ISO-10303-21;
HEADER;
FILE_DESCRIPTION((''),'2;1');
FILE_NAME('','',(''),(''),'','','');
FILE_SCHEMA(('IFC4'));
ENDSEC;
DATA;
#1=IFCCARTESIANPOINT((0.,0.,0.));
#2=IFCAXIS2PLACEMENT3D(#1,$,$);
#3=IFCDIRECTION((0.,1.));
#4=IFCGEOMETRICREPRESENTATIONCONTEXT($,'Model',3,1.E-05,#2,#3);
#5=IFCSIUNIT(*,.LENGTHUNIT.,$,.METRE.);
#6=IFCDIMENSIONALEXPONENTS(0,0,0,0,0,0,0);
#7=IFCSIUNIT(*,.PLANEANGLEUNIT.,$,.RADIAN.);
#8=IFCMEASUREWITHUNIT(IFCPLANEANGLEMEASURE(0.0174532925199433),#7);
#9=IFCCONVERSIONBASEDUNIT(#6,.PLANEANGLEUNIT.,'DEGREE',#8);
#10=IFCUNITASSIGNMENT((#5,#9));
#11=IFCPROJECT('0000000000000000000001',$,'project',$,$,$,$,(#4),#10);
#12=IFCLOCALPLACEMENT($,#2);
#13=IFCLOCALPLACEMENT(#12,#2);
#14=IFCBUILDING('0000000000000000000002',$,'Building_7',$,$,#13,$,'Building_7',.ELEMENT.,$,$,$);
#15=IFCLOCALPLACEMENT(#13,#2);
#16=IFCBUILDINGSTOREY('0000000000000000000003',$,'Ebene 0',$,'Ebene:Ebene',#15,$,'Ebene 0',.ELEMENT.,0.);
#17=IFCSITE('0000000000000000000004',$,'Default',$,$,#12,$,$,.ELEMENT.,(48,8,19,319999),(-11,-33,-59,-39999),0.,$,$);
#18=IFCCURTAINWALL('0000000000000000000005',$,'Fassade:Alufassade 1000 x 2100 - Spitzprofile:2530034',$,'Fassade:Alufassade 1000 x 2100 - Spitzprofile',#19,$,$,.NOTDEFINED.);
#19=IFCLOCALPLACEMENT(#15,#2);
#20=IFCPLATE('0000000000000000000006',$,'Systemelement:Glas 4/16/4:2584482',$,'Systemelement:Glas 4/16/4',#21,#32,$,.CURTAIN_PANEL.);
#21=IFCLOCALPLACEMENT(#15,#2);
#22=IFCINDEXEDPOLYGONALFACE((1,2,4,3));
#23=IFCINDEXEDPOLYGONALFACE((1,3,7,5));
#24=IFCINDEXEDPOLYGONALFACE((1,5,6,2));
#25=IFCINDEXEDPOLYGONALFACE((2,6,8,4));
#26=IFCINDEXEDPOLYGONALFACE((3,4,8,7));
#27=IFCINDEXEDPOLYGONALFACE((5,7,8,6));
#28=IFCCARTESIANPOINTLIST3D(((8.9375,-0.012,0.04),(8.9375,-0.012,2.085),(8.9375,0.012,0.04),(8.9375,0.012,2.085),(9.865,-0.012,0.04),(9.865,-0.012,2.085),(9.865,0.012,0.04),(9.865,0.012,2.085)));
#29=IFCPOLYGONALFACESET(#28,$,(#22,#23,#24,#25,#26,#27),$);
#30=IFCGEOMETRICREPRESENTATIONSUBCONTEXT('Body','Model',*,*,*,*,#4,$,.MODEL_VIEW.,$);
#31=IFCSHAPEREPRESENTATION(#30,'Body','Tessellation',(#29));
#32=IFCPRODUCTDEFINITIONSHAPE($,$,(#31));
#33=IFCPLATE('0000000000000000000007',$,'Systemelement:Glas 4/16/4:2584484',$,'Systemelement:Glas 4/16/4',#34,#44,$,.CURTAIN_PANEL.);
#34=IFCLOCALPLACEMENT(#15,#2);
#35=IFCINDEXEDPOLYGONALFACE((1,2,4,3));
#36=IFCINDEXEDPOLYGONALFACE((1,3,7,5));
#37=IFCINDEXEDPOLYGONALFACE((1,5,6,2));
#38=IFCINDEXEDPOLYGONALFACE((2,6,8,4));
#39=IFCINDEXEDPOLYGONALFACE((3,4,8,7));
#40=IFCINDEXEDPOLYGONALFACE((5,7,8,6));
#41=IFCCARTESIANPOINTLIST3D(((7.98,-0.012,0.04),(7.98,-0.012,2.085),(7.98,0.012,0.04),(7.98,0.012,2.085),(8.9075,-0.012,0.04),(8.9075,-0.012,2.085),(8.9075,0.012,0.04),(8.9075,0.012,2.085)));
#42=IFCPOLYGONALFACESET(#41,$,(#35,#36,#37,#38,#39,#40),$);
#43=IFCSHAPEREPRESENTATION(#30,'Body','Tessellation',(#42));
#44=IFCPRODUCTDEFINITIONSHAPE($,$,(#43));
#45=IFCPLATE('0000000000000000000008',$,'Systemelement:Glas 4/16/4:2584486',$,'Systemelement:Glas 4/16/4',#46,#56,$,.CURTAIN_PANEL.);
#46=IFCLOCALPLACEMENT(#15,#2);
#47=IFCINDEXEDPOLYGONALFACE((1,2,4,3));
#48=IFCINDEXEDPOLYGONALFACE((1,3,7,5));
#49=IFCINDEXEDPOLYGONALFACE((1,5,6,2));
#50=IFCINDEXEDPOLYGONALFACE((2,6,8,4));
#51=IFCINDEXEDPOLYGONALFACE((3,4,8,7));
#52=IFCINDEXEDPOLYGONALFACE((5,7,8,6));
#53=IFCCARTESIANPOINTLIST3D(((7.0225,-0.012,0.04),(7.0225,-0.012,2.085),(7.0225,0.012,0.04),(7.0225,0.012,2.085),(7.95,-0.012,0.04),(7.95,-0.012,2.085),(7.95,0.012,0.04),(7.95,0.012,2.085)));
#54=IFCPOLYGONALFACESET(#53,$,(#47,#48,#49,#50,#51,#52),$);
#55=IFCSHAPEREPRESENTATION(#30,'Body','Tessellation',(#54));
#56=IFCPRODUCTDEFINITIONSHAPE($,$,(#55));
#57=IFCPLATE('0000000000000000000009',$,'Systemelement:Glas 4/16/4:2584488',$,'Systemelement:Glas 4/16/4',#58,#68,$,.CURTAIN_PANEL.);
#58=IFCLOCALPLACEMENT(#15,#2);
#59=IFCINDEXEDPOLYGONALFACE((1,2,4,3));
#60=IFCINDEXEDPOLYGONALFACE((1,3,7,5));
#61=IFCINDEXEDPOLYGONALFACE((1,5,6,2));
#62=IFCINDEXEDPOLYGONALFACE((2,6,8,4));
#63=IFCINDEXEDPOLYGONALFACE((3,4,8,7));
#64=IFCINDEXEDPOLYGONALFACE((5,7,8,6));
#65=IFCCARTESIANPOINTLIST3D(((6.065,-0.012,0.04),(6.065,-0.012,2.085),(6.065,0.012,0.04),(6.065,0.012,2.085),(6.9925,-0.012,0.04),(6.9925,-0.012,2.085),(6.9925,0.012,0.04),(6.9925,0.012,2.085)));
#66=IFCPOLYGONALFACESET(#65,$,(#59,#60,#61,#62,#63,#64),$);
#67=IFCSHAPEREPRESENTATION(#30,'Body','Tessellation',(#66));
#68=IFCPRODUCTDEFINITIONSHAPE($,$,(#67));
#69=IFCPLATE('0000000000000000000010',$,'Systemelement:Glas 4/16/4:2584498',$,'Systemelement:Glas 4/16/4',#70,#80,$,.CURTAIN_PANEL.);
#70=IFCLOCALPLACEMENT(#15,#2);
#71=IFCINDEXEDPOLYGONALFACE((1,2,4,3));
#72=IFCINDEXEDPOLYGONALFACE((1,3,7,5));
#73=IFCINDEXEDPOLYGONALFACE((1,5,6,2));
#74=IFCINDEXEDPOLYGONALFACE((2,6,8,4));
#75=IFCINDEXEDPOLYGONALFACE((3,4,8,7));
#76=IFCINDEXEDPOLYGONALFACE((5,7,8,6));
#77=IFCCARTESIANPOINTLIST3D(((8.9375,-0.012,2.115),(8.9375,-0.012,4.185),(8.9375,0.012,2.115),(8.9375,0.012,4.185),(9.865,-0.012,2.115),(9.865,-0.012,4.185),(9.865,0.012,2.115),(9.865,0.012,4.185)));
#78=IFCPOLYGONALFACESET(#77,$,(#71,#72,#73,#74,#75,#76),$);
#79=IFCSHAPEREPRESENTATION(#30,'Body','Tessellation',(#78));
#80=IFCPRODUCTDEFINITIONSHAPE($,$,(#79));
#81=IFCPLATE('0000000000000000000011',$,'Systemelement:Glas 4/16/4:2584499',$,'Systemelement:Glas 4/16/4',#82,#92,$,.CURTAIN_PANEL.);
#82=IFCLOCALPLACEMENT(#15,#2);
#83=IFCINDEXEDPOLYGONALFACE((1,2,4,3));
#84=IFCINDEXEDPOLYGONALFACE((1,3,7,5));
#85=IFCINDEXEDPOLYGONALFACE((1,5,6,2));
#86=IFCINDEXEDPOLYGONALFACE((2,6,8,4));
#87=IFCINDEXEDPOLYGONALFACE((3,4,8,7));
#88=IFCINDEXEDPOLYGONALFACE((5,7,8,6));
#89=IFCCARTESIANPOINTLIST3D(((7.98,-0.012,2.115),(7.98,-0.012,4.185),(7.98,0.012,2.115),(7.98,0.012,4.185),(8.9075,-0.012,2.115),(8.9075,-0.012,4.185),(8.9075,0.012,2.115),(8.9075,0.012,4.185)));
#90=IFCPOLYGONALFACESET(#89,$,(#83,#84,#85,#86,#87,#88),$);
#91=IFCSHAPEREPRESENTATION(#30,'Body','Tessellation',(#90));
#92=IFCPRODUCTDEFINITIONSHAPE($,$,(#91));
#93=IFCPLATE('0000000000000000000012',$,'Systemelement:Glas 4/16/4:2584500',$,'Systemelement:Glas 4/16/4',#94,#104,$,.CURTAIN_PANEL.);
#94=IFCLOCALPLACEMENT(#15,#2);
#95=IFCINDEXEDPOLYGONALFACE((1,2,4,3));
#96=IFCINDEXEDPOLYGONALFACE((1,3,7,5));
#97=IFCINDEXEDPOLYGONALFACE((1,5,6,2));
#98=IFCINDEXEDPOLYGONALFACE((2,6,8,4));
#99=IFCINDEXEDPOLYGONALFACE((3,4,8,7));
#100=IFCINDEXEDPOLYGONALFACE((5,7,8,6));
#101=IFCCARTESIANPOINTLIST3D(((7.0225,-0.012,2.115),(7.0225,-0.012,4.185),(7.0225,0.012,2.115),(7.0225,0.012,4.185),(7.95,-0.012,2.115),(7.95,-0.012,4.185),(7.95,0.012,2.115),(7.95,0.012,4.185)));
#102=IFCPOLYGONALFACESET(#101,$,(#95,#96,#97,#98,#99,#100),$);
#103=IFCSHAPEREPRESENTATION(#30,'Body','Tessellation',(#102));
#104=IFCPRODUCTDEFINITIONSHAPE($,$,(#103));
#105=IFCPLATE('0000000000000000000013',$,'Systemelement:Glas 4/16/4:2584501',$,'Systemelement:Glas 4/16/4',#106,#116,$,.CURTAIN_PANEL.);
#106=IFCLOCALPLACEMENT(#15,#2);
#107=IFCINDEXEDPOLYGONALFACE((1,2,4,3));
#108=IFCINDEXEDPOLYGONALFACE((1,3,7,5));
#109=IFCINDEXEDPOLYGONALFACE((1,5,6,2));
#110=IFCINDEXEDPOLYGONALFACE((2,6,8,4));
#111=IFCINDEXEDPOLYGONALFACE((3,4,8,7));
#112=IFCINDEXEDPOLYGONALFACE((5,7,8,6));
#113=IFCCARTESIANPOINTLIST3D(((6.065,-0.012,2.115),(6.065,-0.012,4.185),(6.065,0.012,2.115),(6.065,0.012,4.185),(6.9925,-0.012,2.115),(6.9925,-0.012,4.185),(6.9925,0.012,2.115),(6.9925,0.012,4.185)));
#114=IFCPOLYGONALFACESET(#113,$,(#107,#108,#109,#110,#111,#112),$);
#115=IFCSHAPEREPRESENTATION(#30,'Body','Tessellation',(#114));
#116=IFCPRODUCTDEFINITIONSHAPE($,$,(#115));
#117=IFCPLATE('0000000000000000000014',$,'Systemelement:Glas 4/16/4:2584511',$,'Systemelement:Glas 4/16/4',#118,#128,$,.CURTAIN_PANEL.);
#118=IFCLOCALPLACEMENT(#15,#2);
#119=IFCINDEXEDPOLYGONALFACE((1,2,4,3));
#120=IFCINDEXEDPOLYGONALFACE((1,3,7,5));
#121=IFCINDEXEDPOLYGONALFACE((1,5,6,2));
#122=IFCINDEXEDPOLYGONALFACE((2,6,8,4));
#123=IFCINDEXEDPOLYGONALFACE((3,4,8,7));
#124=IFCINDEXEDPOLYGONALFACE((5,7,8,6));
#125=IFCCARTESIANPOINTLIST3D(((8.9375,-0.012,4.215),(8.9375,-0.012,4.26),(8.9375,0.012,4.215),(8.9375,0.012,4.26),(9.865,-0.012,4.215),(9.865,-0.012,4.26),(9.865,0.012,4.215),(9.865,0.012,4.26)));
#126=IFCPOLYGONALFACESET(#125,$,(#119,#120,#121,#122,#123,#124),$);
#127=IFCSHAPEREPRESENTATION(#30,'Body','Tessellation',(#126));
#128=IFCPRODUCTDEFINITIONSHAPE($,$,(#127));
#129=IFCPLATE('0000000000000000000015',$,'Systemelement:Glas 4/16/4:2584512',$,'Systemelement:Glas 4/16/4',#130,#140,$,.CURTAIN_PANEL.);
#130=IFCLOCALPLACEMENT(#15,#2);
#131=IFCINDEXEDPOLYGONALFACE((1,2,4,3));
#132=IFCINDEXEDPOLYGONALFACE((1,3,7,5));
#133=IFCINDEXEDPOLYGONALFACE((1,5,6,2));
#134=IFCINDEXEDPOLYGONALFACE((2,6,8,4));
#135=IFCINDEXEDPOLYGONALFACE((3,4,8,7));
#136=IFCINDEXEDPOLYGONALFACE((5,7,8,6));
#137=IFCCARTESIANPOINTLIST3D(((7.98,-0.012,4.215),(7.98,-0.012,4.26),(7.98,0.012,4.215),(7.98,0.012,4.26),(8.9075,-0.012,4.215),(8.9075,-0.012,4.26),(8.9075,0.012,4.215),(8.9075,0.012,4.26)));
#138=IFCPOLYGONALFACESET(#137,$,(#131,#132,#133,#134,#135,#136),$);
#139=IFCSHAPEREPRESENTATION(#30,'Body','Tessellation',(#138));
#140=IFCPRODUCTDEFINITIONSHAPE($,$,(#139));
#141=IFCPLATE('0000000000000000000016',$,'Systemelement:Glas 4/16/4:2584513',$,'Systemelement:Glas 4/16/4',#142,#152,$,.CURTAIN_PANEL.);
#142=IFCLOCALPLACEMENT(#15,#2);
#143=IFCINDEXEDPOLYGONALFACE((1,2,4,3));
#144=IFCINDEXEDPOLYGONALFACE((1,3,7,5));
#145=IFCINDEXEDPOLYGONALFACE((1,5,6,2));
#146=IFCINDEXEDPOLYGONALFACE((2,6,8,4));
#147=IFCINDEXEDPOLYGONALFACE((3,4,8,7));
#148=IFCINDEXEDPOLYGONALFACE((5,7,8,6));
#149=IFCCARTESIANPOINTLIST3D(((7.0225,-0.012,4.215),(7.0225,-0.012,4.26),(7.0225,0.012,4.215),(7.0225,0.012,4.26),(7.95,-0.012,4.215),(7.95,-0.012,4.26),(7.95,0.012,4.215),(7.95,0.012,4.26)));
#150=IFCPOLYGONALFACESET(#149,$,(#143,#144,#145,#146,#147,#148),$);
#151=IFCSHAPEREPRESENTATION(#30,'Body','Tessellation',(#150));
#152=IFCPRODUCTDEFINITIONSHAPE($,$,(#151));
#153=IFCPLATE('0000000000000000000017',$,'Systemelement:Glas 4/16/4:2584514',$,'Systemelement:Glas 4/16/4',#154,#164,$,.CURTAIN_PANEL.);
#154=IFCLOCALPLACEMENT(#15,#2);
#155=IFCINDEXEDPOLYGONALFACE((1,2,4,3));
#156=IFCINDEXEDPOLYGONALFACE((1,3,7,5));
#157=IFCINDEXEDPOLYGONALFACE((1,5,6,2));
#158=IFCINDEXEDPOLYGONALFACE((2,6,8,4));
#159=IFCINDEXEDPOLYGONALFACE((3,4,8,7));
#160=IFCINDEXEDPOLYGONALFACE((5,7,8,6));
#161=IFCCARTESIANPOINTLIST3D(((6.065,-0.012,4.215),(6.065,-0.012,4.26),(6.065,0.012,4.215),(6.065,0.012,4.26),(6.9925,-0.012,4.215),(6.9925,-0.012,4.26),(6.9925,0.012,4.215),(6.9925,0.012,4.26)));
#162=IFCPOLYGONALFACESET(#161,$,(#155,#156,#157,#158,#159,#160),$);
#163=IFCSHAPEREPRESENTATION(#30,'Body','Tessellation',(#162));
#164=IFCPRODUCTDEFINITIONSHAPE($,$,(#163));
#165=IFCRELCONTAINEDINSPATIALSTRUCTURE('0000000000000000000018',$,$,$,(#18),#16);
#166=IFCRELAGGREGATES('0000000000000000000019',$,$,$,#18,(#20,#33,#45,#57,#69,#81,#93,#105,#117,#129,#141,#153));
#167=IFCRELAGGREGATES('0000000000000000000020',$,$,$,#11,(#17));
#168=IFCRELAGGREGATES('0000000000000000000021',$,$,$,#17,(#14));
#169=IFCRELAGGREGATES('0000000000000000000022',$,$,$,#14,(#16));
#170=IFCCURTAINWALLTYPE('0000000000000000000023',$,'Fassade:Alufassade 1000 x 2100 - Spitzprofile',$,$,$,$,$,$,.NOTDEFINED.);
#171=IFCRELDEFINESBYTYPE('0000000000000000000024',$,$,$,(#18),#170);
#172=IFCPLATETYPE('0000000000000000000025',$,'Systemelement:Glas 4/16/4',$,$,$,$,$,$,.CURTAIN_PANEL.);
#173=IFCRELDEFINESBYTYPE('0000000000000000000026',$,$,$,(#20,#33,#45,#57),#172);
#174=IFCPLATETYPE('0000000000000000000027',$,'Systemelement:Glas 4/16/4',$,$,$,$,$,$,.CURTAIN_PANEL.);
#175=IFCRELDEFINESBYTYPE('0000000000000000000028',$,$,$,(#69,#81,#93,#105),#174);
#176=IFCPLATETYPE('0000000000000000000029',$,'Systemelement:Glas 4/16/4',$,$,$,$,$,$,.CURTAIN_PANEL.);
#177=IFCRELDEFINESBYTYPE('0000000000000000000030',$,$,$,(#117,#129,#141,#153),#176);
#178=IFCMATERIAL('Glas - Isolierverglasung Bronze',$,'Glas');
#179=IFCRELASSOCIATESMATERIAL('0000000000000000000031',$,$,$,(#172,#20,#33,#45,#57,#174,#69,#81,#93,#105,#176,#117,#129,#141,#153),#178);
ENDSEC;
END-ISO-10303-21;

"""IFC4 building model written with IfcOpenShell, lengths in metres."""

from ifc_helpers import new_model, entity, si_unit, converted_unit, direction, frame, origin, place, context, subcontext, project, spatial, indexed_curve, outline, extrude, source, transform, mapped, material, type_object, type_shapes, element, aggregate, save


model = new_model("IFC4")

# Units and contexts
model_context = context("Model", 3, precision=1e-05, world=origin(), true_north=direction((0.0, 1.0)))
body_context = subcontext(model_context, "Body", "Model", "MODEL_VIEW")
ifc_project = project(units=[si_unit("LENGTHUNIT", "METRE"), converted_unit("PLANEANGLEUNIT", "DEGREE", entity("IfcPlaneAngleMeasure", 0.0174532925199433), si_unit("PLANEANGLEUNIT", "RADIAN"), dimensions=[0, 0, 0, 0, 0, 0, 0])], contexts=[model_context])

# Site, building, storey
site_placement = place(None, origin())
site = spatial("IfcSite", under=ifc_project, at=site_placement, Name="Default", CompositionType="ELEMENT", RefLatitude=(48, 8, 19, 319999), RefLongitude=(-11, -33, -59, -39999), RefElevation=0.0)
building_placement = place(site_placement, origin())
building = spatial("IfcBuilding", under=site, at=building_placement, Name="Building_7", LongName="Building_7", CompositionType="ELEMENT")
storey_placement = place(building_placement, origin())
storey = spatial("IfcBuildingStorey", under=building, at=storey_placement, Name="Ebene 0", ObjectType="Ebene:Ebene", LongName="Ebene 0", CompositionType="ELEMENT", Elevation=0.0)

# Curtain wall
curtain_wall_type = type_object("IfcCurtainWallType", Name="Fassade:Alufassade 1000 x 2100 - Spitzprofile", PredefinedType="NOTDEFINED")
curtain_wall_1_placement = place(storey_placement, origin())
curtain_wall_1 = element("IfcCurtainWall", 1, at=curtain_wall_1_placement, inside=storey, type_object=curtain_wall_type, Name="Fassade:Alufassade 1000 x 2100 - Spitzprofile:2530034", ObjectType="Fassade:Alufassade 1000 x 2100 - Spitzprofile", PredefinedType="NOTDEFINED")

# Plates
ifc_material_1 = material(Name="Glas - Isolierverglasung Bronze", Category="Glas")
plate_type_1 = type_object("IfcPlateType", Name="Systemelement:Glas 4/16/4", PredefinedType="CURTAIN_PANEL", material=ifc_material_1)
shared_shape_1 = source(origin(), body_context, "Body", "SweptSolid", [
    extrude(outline(indexed_curve([(-0.012, -0.4637), (0.012, -0.4637), (0.012, 0.4637), (-0.012, 0.4637), (-0.012, -0.4637)], self_intersect=False)), frame((0.0, 0.0, 0.0), z_axis=(0.0, 0.0, 1.0), x_axis=(0.0, 1.0, 0.0)), (0.0, 0.0, 1.0), 2.045),
])
type_shapes(plate_type_1, [shared_shape_1])
plate_1_placement = place(curtain_wall_1_placement, frame((9.4013, 0.0, 0.04), z_axis=(0.0, 0.0, 1.0), x_axis=(-1.0, 0.0, 0.0)))
plate_1 = element("IfcPlate", 2, at=plate_1_placement, type_object=plate_type_1, material=ifc_material_1, Name="Systemelement:Glas 4/16/4:2584482", ObjectType="Systemelement:Glas 4/16/4", PredefinedType="CURTAIN_PANEL", context=body_context, shape_type="MappedRepresentation", body=[
    mapped(shared_shape_1, transform((0.0, 0.0, 0.0), scale=1.0)),
])
plate_2_placement = place(curtain_wall_1_placement, frame((8.4438, 0.0, 0.04), z_axis=(0.0, 0.0, 1.0), x_axis=(-1.0, 0.0, 0.0)))
plate_2 = element("IfcPlate", 3, at=plate_2_placement, type_object=plate_type_1, material=ifc_material_1, Name="Systemelement:Glas 4/16/4:2584484", ObjectType="Systemelement:Glas 4/16/4", PredefinedType="CURTAIN_PANEL", context=body_context, shape_type="MappedRepresentation", body=[
    mapped(shared_shape_1, transform((0.0, 0.0, 0.0), scale=1.0)),
])
plate_3_placement = place(curtain_wall_1_placement, frame((7.4863, 0.0, 0.04), z_axis=(0.0, 0.0, 1.0), x_axis=(-1.0, 0.0, 0.0)))
plate_3 = element("IfcPlate", 4, at=plate_3_placement, type_object=plate_type_1, material=ifc_material_1, Name="Systemelement:Glas 4/16/4:2584486", ObjectType="Systemelement:Glas 4/16/4", PredefinedType="CURTAIN_PANEL", context=body_context, shape_type="MappedRepresentation", body=[
    mapped(shared_shape_1, transform((0.0, 0.0, 0.0), scale=1.0)),
])
plate_4_placement = place(curtain_wall_1_placement, frame((6.5288, 0.0, 0.04), z_axis=(0.0, 0.0, 1.0), x_axis=(-1.0, 0.0, 0.0)))
plate_4 = element("IfcPlate", 5, at=plate_4_placement, type_object=plate_type_1, material=ifc_material_1, Name="Systemelement:Glas 4/16/4:2584488", ObjectType="Systemelement:Glas 4/16/4", PredefinedType="CURTAIN_PANEL", context=body_context, shape_type="MappedRepresentation", body=[
    mapped(shared_shape_1, transform((0.0, 0.0, 0.0), scale=1.0)),
])
plate_type_2 = type_object("IfcPlateType", Name="Systemelement:Glas 4/16/4", PredefinedType="CURTAIN_PANEL", material=ifc_material_1)
shared_shape_2 = source(origin(), body_context, "Body", "SweptSolid", [
    extrude(outline(indexed_curve([(-0.012, -0.4637), (0.012, -0.4637), (0.012, 0.4637), (-0.012, 0.4637), (-0.012, -0.4637)], self_intersect=False)), frame((0.0, 0.0, 0.0), z_axis=(0.0, 0.0, 1.0), x_axis=(0.0, 1.0, 0.0)), (0.0, 0.0, 1.0), 2.07),
])
type_shapes(plate_type_2, [shared_shape_2])
plate_5_placement = place(curtain_wall_1_placement, frame((9.4013, 0.0, 2.115), z_axis=(0.0, 0.0, 1.0), x_axis=(-1.0, 0.0, 0.0)))
plate_5 = element("IfcPlate", 6, at=plate_5_placement, type_object=plate_type_2, material=ifc_material_1, Name="Systemelement:Glas 4/16/4:2584498", ObjectType="Systemelement:Glas 4/16/4", PredefinedType="CURTAIN_PANEL", context=body_context, shape_type="MappedRepresentation", body=[
    mapped(shared_shape_2, transform((0.0, 0.0, 0.0), scale=1.0)),
])
plate_6_placement = place(curtain_wall_1_placement, frame((8.4438, 0.0, 2.115), z_axis=(0.0, 0.0, 1.0), x_axis=(-1.0, 0.0, 0.0)))
plate_6 = element("IfcPlate", 7, at=plate_6_placement, type_object=plate_type_2, material=ifc_material_1, Name="Systemelement:Glas 4/16/4:2584499", ObjectType="Systemelement:Glas 4/16/4", PredefinedType="CURTAIN_PANEL", context=body_context, shape_type="MappedRepresentation", body=[
    mapped(shared_shape_2, transform((0.0, 0.0, 0.0), scale=1.0)),
])
plate_7_placement = place(curtain_wall_1_placement, frame((7.4863, 0.0, 2.115), z_axis=(0.0, 0.0, 1.0), x_axis=(-1.0, 0.0, 0.0)))
plate_7 = element("IfcPlate", 8, at=plate_7_placement, type_object=plate_type_2, material=ifc_material_1, Name="Systemelement:Glas 4/16/4:2584500", ObjectType="Systemelement:Glas 4/16/4", PredefinedType="CURTAIN_PANEL", context=body_context, shape_type="MappedRepresentation", body=[
    mapped(shared_shape_2, transform((0.0, 0.0, 0.0), scale=1.0)),
])
plate_8_placement = place(curtain_wall_1_placement, frame((6.5288, 0.0, 2.115), z_axis=(0.0, 0.0, 1.0), x_axis=(-1.0, 0.0, 0.0)))
plate_8 = element("IfcPlate", 9, at=plate_8_placement, type_object=plate_type_2, material=ifc_material_1, Name="Systemelement:Glas 4/16/4:2584501", ObjectType="Systemelement:Glas 4/16/4", PredefinedType="CURTAIN_PANEL", context=body_context, shape_type="MappedRepresentation", body=[
    mapped(shared_shape_2, transform((0.0, 0.0, 0.0), scale=1.0)),
])
plate_type_3 = type_object("IfcPlateType", Name="Systemelement:Glas 4/16/4", PredefinedType="CURTAIN_PANEL", material=ifc_material_1)
shared_shape_3 = source(origin(), body_context, "Body", "SweptSolid", [
    extrude(outline(indexed_curve([(-0.012, -0.4637), (0.012, -0.4637), (0.012, 0.4637), (-0.012, 0.4637), (-0.012, -0.4637)], self_intersect=False)), frame((0.0, 0.0, 0.0), z_axis=(0.0, 0.0, 1.0), x_axis=(0.0, 1.0, 0.0)), (0.0, 0.0, 1.0), 0.045),
])
type_shapes(plate_type_3, [shared_shape_3])
plate_9_placement = place(curtain_wall_1_placement, frame((9.4013, 0.0, 4.215), z_axis=(0.0, 0.0, 1.0), x_axis=(-1.0, 0.0, 0.0)))
plate_9 = element("IfcPlate", 10, at=plate_9_placement, type_object=plate_type_3, material=ifc_material_1, Name="Systemelement:Glas 4/16/4:2584511", ObjectType="Systemelement:Glas 4/16/4", PredefinedType="CURTAIN_PANEL", context=body_context, shape_type="MappedRepresentation", body=[
    mapped(shared_shape_3, transform((0.0, 0.0, 0.0), scale=1.0)),
])
plate_10_placement = place(curtain_wall_1_placement, frame((8.4438, 0.0, 4.215), z_axis=(0.0, 0.0, 1.0), x_axis=(-1.0, 0.0, 0.0)))
plate_10 = element("IfcPlate", 11, at=plate_10_placement, type_object=plate_type_3, material=ifc_material_1, Name="Systemelement:Glas 4/16/4:2584512", ObjectType="Systemelement:Glas 4/16/4", PredefinedType="CURTAIN_PANEL", context=body_context, shape_type="MappedRepresentation", body=[
    mapped(shared_shape_3, transform((0.0, 0.0, 0.0), scale=1.0)),
])
plate_11_placement = place(curtain_wall_1_placement, frame((7.4863, 0.0, 4.215), z_axis=(0.0, 0.0, 1.0), x_axis=(-1.0, 0.0, 0.0)))
plate_11 = element("IfcPlate", 12, at=plate_11_placement, type_object=plate_type_3, material=ifc_material_1, Name="Systemelement:Glas 4/16/4:2584513", ObjectType="Systemelement:Glas 4/16/4", PredefinedType="CURTAIN_PANEL", context=body_context, shape_type="MappedRepresentation", body=[
    mapped(shared_shape_3, transform((0.0, 0.0, 0.0), scale=1.0)),
])
plate_12_placement = place(curtain_wall_1_placement, frame((6.5288, 0.0, 4.215), z_axis=(0.0, 0.0, 1.0), x_axis=(-1.0, 0.0, 0.0)))
plate_12 = element("IfcPlate", 13, at=plate_12_placement, type_object=plate_type_3, material=ifc_material_1, Name="Systemelement:Glas 4/16/4:2584514", ObjectType="Systemelement:Glas 4/16/4", PredefinedType="CURTAIN_PANEL", context=body_context, shape_type="MappedRepresentation", body=[
    mapped(shared_shape_3, transform((0.0, 0.0, 0.0), scale=1.0)),
])
aggregate(curtain_wall_1, [plate_1, plate_2, plate_3, plate_4, plate_5, plate_6, plate_7, plate_8, plate_9, plate_10, plate_11, plate_12])

save(model, "model.ifc")
